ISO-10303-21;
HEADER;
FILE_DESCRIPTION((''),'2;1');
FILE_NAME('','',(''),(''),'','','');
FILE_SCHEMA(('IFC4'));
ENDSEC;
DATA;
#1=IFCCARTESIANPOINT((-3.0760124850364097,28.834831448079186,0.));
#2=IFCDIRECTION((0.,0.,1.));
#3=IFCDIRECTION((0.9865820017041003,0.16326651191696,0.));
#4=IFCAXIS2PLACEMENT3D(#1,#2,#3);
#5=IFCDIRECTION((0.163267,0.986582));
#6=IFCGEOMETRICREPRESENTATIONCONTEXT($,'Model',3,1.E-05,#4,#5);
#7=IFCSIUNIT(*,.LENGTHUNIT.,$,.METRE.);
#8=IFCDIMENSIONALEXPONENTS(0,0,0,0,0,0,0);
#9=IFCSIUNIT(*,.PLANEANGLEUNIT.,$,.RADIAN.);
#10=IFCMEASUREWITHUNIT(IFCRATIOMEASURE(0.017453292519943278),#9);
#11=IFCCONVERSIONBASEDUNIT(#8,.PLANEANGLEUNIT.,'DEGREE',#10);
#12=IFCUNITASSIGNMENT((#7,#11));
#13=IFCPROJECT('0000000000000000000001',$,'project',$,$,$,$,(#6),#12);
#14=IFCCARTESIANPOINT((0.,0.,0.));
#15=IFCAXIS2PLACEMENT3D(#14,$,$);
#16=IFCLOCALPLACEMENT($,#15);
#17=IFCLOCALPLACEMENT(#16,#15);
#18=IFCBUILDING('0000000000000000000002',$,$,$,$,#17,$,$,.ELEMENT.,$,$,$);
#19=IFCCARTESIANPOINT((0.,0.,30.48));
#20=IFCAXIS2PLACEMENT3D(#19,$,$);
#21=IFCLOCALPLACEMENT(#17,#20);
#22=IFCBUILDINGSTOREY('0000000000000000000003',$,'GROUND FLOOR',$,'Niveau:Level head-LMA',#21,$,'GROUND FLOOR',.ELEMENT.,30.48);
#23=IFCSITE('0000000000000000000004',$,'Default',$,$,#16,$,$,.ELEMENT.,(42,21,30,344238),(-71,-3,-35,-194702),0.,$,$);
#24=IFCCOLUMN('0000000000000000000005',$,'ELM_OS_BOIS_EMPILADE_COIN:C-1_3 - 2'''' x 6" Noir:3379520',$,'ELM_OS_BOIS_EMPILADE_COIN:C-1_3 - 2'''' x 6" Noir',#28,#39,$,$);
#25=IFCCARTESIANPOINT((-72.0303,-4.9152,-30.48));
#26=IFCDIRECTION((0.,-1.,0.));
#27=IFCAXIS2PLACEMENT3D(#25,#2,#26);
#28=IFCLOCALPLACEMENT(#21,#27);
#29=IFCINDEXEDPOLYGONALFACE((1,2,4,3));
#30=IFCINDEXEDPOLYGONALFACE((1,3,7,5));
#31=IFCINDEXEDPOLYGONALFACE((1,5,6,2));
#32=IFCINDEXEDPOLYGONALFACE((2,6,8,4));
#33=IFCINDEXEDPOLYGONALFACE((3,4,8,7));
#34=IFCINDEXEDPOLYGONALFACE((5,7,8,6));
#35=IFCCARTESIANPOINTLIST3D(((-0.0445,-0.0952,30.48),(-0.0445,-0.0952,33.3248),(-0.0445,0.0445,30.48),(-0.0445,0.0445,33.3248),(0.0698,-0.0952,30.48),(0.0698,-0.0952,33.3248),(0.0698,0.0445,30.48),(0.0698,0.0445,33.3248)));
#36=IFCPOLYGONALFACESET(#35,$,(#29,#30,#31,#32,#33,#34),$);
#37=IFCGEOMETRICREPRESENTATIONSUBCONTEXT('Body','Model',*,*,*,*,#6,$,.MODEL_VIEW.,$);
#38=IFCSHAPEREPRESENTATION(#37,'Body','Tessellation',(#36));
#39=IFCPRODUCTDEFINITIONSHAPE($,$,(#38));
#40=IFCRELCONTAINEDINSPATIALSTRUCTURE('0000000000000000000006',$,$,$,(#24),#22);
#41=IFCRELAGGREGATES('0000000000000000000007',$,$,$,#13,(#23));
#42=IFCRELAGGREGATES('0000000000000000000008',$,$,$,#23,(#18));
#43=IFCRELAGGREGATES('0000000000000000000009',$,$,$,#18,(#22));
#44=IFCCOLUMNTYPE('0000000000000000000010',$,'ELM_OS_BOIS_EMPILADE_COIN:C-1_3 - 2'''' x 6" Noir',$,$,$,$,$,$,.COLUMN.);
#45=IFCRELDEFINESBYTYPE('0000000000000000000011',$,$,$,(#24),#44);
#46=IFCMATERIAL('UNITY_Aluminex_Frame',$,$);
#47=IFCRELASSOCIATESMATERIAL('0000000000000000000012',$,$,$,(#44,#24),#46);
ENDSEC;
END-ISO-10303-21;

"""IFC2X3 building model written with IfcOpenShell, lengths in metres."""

from ifc_helpers import new_model, entity, si_unit, converted_unit, direction, frame, origin, origin_2d_with_axis, place, context, subcontext, project, spatial, rectangle, extrude, source, transform, mapped, material, type_object, type_shapes, element, save


model = new_model("IFC2X3")

# Units and contexts
model_context = context("Model", 3, precision=1e-05, world=frame((-3.0760124850364097, 28.834831448079186, 0.0), z_axis=(0.0, 0.0, 1.0), x_axis=(0.9865820017041003, 0.16326651191696, 0.0)), true_north=direction((0.163267, 0.986582)))
body_context = subcontext(model_context, "Body", "Model", "MODEL_VIEW")
ifc_project = project(units=[si_unit("LENGTHUNIT", "METRE"), converted_unit("PLANEANGLEUNIT", "DEGREE", entity("IfcRatioMeasure", 0.017453292519943278), si_unit("PLANEANGLEUNIT", "RADIAN"), dimensions=[0, 0, 0, 0, 0, 0, 0])], contexts=[model_context])

# Site, building, storey
site_placement = place(None, origin())
site = spatial("IfcSite", under=ifc_project, at=site_placement, Name="Default", CompositionType="ELEMENT", RefLatitude=(42, 21, 30, 344238), RefLongitude=(-71, -3, -35, -194702), RefElevation=0.0)
building_placement = place(site_placement, origin())
building = spatial("IfcBuilding", under=site, at=building_placement, CompositionType="ELEMENT")
storey_placement = place(building_placement, frame((0.0, 0.0, 30.48)))
storey = spatial("IfcBuildingStorey", under=building, at=storey_placement, Name="GROUND FLOOR", ObjectType="Niveau:Level head-LMA", LongName="GROUND FLOOR", CompositionType="ELEMENT", Elevation=30.48)

# Column
ifc_material_1 = material(Name="UNITY_Aluminex_Frame")
column_type = type_object("IfcColumnType", Name="ELM_OS_BOIS_EMPILADE_COIN:C-1_3 - 2'' x 6\" Noir", PredefinedType="COLUMN", material=ifc_material_1)
shared_shape = source(origin(), body_context, "Body", "SweptSolid", [
    extrude(rectangle(XDim=0.1397, YDim=0.1143, at=origin_2d_with_axis()), frame((0.0126, -0.0253, 30.48), z_axis=(0.0, 0.0, 1.0), x_axis=(0.0, -1.0, 0.0)), (0.0, 0.0, 1.0), 2.8448),
])
type_shapes(column_type, [shared_shape])
column_placement = place(storey_placement, frame((-72.0303, -4.9152, -30.48), z_axis=(0.0, 0.0, 1.0), x_axis=(0.0, -1.0, 0.0)))
element("IfcColumn", 1, at=column_placement, inside=storey, type_object=column_type, material=ifc_material_1, Name="ELM_OS_BOIS_EMPILADE_COIN:C-1_3 - 2'' x 6\" Noir:3379520", ObjectType="ELM_OS_BOIS_EMPILADE_COIN:C-1_3 - 2'' x 6\" Noir", context=body_context, shape_type="MappedRepresentation", body=[
    mapped(shared_shape, transform((0.0, 0.0, 0.0), scale=1.0)),
])

save(model, "model.ifc")
